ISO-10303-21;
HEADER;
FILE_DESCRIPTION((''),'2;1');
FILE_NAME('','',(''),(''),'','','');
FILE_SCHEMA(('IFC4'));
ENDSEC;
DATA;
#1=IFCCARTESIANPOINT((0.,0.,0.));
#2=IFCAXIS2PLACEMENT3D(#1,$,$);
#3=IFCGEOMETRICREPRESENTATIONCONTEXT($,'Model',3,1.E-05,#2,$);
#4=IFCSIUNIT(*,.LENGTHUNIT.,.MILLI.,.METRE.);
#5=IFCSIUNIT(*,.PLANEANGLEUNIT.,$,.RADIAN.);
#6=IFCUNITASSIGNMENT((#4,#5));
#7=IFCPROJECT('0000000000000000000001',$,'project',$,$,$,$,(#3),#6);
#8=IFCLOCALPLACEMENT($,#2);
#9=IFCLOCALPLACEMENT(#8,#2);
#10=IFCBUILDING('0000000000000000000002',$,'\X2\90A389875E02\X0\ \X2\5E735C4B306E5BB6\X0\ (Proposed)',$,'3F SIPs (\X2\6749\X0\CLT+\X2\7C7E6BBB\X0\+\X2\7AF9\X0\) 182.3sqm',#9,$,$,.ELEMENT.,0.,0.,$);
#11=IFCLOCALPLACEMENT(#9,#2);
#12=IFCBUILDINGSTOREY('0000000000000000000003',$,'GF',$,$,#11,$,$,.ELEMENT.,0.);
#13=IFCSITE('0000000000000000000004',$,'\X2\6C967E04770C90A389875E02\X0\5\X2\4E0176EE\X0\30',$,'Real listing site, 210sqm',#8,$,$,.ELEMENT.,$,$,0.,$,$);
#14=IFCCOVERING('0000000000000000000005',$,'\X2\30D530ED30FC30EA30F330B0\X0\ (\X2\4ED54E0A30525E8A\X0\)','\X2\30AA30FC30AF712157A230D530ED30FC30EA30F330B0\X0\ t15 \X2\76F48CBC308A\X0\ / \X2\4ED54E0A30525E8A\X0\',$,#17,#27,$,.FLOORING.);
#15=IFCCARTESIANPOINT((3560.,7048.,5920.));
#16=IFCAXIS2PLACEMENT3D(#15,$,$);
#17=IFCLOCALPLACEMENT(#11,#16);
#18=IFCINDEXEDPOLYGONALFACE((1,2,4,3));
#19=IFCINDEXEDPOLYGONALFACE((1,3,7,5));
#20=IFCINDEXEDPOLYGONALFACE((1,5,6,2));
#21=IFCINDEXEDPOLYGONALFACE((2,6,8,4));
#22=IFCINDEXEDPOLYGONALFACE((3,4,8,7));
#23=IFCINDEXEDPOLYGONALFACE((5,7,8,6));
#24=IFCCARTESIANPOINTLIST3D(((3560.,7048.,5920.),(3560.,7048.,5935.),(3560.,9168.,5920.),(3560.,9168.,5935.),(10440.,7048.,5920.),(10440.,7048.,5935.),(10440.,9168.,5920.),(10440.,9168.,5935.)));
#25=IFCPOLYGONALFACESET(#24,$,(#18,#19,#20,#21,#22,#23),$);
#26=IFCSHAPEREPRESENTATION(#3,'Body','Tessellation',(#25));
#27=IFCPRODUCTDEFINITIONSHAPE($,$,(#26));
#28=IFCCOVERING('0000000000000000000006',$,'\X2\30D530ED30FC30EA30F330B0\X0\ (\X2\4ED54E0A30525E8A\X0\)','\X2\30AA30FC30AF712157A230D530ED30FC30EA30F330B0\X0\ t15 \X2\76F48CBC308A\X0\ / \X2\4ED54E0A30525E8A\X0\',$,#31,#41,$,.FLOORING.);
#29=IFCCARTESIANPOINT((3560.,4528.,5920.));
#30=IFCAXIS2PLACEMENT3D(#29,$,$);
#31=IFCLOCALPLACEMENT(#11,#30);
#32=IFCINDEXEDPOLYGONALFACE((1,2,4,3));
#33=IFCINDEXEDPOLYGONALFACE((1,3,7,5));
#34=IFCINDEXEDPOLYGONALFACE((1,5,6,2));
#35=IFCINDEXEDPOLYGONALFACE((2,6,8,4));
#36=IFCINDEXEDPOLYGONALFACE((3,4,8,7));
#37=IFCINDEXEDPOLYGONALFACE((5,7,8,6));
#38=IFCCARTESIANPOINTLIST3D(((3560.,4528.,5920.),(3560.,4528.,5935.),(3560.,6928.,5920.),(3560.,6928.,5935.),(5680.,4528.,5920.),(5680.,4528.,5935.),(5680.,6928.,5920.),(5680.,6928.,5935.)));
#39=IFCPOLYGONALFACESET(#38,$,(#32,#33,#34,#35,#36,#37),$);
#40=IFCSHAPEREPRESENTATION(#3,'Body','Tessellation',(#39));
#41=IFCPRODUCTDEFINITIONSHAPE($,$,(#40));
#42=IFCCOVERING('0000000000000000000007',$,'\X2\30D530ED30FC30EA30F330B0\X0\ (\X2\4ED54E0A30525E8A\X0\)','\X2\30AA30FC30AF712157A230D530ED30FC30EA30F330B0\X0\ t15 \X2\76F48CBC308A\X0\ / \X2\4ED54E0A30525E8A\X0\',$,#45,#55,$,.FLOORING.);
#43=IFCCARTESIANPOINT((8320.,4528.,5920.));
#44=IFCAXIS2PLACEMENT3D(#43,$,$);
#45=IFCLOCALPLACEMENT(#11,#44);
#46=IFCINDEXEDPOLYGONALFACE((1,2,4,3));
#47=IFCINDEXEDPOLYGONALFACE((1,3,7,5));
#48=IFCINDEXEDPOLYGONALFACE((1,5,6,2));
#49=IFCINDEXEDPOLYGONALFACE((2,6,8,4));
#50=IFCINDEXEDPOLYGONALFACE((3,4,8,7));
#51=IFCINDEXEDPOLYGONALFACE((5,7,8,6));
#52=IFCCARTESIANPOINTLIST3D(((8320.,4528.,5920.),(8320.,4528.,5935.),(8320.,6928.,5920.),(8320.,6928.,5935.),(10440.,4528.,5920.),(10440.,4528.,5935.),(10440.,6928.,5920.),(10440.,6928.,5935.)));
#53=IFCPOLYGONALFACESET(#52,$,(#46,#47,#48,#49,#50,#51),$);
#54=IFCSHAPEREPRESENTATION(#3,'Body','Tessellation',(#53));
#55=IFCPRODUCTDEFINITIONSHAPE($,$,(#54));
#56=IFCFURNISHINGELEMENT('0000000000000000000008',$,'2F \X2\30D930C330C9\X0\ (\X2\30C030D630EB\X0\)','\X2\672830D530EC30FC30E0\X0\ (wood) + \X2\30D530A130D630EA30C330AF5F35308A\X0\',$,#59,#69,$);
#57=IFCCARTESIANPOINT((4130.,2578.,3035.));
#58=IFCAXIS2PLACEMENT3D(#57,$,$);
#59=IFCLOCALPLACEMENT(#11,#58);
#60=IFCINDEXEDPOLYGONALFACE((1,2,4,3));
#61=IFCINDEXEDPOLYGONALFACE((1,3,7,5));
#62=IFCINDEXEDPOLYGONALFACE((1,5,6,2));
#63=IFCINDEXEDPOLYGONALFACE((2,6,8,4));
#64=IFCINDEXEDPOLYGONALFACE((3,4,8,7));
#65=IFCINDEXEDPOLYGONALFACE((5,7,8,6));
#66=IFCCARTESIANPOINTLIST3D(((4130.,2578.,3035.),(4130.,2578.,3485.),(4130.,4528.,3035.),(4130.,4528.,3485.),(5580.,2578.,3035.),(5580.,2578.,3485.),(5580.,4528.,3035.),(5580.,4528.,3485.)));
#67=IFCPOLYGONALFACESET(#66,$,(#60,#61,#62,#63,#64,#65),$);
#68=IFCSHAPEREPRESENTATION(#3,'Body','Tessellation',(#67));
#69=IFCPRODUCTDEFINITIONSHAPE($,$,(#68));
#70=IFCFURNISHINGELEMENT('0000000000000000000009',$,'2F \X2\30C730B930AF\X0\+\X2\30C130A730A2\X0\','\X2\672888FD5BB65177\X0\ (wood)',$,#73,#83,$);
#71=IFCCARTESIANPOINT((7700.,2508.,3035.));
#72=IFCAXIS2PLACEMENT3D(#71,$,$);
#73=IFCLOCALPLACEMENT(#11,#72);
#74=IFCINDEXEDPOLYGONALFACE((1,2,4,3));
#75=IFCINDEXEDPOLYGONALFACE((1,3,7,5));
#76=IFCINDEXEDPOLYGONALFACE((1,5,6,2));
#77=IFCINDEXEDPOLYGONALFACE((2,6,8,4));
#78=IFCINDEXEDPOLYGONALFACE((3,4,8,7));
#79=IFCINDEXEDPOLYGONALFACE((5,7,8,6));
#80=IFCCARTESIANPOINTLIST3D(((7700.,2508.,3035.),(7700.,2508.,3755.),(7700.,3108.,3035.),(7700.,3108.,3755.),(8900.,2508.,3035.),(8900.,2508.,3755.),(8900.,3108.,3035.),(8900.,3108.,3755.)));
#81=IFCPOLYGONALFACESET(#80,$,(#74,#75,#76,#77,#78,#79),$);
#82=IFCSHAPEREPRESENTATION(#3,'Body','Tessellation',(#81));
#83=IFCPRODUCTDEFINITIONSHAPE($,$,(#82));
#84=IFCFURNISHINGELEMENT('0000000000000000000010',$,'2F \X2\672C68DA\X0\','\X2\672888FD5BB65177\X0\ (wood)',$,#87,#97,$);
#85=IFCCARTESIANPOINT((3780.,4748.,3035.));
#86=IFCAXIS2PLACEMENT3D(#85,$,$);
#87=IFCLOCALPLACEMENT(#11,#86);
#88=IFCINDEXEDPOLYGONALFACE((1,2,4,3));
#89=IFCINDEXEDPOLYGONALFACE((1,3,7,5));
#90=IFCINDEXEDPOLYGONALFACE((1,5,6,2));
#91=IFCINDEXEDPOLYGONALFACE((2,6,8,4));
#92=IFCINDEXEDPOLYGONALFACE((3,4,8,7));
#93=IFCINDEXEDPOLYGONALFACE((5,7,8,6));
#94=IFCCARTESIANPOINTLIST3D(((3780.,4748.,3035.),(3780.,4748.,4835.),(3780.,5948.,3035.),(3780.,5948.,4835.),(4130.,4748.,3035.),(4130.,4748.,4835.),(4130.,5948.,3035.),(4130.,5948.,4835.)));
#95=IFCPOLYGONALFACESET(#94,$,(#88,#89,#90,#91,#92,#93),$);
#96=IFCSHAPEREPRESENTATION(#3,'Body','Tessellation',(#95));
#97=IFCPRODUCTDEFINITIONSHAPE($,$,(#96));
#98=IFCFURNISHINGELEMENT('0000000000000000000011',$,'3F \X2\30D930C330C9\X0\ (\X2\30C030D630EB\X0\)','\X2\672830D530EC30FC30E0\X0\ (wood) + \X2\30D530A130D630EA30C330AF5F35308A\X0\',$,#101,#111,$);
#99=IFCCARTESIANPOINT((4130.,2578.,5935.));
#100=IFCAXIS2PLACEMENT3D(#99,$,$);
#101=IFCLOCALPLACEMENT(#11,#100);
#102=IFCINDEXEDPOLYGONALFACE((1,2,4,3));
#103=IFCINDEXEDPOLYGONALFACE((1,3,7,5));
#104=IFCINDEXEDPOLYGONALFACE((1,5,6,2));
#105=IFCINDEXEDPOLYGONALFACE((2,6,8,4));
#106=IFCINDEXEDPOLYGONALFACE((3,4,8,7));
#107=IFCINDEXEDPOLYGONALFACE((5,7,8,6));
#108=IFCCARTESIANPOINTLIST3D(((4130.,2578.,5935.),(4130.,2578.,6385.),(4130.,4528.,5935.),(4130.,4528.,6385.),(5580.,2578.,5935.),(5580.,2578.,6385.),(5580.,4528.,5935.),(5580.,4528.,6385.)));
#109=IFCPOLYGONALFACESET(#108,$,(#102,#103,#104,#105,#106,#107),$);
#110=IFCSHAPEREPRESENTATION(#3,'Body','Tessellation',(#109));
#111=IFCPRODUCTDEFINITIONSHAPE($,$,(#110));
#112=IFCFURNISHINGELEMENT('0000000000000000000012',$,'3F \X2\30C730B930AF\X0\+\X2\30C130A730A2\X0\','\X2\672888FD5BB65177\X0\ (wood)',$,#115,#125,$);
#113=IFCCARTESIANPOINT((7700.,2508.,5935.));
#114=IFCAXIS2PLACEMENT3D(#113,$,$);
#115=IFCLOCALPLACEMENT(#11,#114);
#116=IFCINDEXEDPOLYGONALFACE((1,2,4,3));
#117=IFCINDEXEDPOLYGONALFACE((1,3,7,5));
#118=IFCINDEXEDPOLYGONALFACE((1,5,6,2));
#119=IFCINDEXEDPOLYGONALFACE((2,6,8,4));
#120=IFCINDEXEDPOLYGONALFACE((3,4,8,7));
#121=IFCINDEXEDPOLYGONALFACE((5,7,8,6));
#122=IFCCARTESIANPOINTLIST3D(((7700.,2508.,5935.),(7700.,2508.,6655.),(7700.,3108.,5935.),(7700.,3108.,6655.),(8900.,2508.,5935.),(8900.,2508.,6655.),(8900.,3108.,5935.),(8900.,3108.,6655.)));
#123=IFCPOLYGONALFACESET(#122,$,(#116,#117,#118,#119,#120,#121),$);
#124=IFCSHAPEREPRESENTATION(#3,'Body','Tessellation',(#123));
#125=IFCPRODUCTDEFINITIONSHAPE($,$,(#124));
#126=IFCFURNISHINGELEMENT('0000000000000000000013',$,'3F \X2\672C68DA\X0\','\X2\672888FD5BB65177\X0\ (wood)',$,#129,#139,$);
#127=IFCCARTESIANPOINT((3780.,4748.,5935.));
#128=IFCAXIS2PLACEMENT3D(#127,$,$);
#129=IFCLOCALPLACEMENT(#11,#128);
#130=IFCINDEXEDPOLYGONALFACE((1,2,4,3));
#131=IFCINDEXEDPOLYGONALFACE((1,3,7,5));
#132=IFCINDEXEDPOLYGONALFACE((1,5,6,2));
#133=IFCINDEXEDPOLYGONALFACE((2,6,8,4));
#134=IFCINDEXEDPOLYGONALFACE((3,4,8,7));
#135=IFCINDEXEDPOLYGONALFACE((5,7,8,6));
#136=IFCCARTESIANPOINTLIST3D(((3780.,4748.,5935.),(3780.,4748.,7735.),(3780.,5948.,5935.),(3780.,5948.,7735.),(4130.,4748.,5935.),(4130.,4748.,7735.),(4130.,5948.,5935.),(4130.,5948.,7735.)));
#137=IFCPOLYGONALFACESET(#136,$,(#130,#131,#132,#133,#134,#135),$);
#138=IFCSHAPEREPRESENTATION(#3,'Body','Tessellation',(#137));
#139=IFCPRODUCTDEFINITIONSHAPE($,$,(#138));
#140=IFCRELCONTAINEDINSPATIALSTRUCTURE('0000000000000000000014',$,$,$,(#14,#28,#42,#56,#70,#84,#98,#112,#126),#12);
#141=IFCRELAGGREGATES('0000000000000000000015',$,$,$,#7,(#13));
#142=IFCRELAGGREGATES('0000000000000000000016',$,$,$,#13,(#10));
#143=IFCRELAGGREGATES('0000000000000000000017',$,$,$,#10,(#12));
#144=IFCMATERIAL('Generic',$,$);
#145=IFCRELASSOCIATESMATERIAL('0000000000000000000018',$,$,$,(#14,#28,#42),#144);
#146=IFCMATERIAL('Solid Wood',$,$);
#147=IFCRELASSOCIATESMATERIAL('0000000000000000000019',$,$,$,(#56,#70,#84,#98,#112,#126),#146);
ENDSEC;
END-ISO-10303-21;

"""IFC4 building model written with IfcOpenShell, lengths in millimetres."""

from ifc_helpers import new_model, si_unit, frame, frame_2d, origin, place, context, project, spatial, rectangle, extrude, material, element, save


model = new_model("IFC4")

# Units and contexts
model_context = context("Model", 3, precision=1e-05, world=origin())
ifc_project = project(units=[si_unit("LENGTHUNIT", "METRE", prefix="MILLI"), si_unit("PLANEANGLEUNIT", "RADIAN")], contexts=[model_context])

# Site, building, storey
site_placement = place(None, origin())
site = spatial("IfcSite", under=ifc_project, at=site_placement, Name="沖縄県那覇市5丁目30", ObjectType="Real listing site, 210sqm", CompositionType="ELEMENT", RefElevation=0.0)
building_placement = place(site_placement, origin())
building = spatial("IfcBuilding", under=site, at=building_placement, Name="那覇市 平屋の家 (Proposed)", ObjectType="3F SIPs (杉CLT+籾殻+竹) 182.3sqm", CompositionType="ELEMENT", ElevationOfRefHeight=0.0, ElevationOfTerrain=0.0)
storey_placement = place(building_placement, origin())
storey = spatial("IfcBuildingStorey", under=building, at=storey_placement, Name="GF", CompositionType="ELEMENT", Elevation=0.0)

# Shared definitions
ifc_material_1 = material(Name="Solid Wood")

# Shared definitions
ifc_material_2 = material(Name="Generic")

# Coverings
covering_1_placement = place(storey_placement, frame((3560.0, 7048.0, 5920.0)))
element("IfcCovering", 1, at=covering_1_placement, inside=storey, material=ifc_material_2, Name="フローリング (仕上げ床)", Description="オーク無垢フローリング t15 直貼り / 仕上げ床", PredefinedType="FLOORING", context=model_context, shape_type="SweptSolid", body=[
    extrude(rectangle(XDim=6880.0, YDim=2120.0, at=frame_2d((3440.0, 1060.0))), frame((3560.0, 7048.0, 5920.0)), (0.0, 0.0, 1.0), 15.0),
])
covering_2_placement = place(storey_placement, frame((3560.0, 4528.0, 5920.0)))
element("IfcCovering", 2, at=covering_2_placement, inside=storey, material=ifc_material_2, Name="フローリング (仕上げ床)", Description="オーク無垢フローリング t15 直貼り / 仕上げ床", PredefinedType="FLOORING", context=model_context, shape_type="SweptSolid", body=[
    extrude(rectangle(XDim=2120.0, YDim=2400.0, at=frame_2d((1060.0, 1200.0))), frame((3560.0, 4528.0, 5920.0)), (0.0, 0.0, 1.0), 15.0),
])
covering_3_placement = place(storey_placement, frame((8320.0, 4528.0, 5920.0)))
element("IfcCovering", 3, at=covering_3_placement, inside=storey, material=ifc_material_2, Name="フローリング (仕上げ床)", Description="オーク無垢フローリング t15 直貼り / 仕上げ床", PredefinedType="FLOORING", context=model_context, shape_type="SweptSolid", body=[
    extrude(rectangle(XDim=2120.0, YDim=2400.0, at=frame_2d((1060.0, 1200.0))), frame((8320.0, 4528.0, 5920.0)), (0.0, 0.0, 1.0), 15.0),
])

# Furnishing elements
furnishing_1_placement = place(storey_placement, frame((4130.0, 2578.0, 3035.0)))
element("IfcFurnishingElement", 4, at=furnishing_1_placement, inside=storey, material=ifc_material_1, Name="2F ベッド (ダブル)", Description="木フレーム (wood) + ファブリック張り", context=model_context, shape_type="SweptSolid", body=[
    extrude(rectangle(XDim=1450.0, YDim=1950.0, at=frame_2d((725.0, 975.0))), frame((4130.0, 2578.0, 3035.0)), (0.0, 0.0, 1.0), 450.0),
])
furnishing_2_placement = place(storey_placement, frame((7700.0, 2508.0, 3035.0)))
element("IfcFurnishingElement", 5, at=furnishing_2_placement, inside=storey, material=ifc_material_1, Name="2F デスク+チェア", Description="木製家具 (wood)", context=model_context, shape_type="SweptSolid", body=[
    extrude(rectangle(XDim=1200.0, YDim=600.0, at=frame_2d((600.0, 300.0))), frame((7700.0, 2508.0, 3035.0)), (0.0, 0.0, 1.0), 720.0),
])
furnishing_3_placement = place(storey_placement, frame((3780.0, 4748.0, 3035.0)))
element("IfcFurnishingElement", 6, at=furnishing_3_placement, inside=storey, material=ifc_material_1, Name="2F 本棚", Description="木製家具 (wood)", context=model_context, shape_type="SweptSolid", body=[
    extrude(rectangle(XDim=350.0, YDim=1200.0, at=frame_2d((175.0, 600.0))), frame((3780.0, 4748.0, 3035.0)), (0.0, 0.0, 1.0), 1800.0),
])
furnishing_4_placement = place(storey_placement, frame((4130.0, 2578.0, 5935.0)))
element("IfcFurnishingElement", 7, at=furnishing_4_placement, inside=storey, material=ifc_material_1, Name="3F ベッド (ダブル)", Description="木フレーム (wood) + ファブリック張り", context=model_context, shape_type="SweptSolid", body=[
    extrude(rectangle(XDim=1450.0, YDim=1950.0, at=frame_2d((725.0, 975.0))), frame((4130.0, 2578.0, 5935.0)), (0.0, 0.0, 1.0), 450.0),
])
furnishing_5_placement = place(storey_placement, frame((7700.0, 2508.0, 5935.0)))
element("IfcFurnishingElement", 8, at=furnishing_5_placement, inside=storey, material=ifc_material_1, Name="3F デスク+チェア", Description="木製家具 (wood)", context=model_context, shape_type="SweptSolid", body=[
    extrude(rectangle(XDim=1200.0, YDim=600.0, at=frame_2d((600.0, 300.0))), frame((7700.0, 2508.0, 5935.0)), (0.0, 0.0, 1.0), 720.0),
])
furnishing_6_placement = place(storey_placement, frame((3780.0, 4748.0, 5935.0)))
element("IfcFurnishingElement", 9, at=furnishing_6_placement, inside=storey, material=ifc_material_1, Name="3F 本棚", Description="木製家具 (wood)", context=model_context, shape_type="SweptSolid", body=[
    extrude(rectangle(XDim=350.0, YDim=1200.0, at=frame_2d((175.0, 600.0))), frame((3780.0, 4748.0, 5935.0)), (0.0, 0.0, 1.0), 1800.0),
])

save(model, "model.ifc")
